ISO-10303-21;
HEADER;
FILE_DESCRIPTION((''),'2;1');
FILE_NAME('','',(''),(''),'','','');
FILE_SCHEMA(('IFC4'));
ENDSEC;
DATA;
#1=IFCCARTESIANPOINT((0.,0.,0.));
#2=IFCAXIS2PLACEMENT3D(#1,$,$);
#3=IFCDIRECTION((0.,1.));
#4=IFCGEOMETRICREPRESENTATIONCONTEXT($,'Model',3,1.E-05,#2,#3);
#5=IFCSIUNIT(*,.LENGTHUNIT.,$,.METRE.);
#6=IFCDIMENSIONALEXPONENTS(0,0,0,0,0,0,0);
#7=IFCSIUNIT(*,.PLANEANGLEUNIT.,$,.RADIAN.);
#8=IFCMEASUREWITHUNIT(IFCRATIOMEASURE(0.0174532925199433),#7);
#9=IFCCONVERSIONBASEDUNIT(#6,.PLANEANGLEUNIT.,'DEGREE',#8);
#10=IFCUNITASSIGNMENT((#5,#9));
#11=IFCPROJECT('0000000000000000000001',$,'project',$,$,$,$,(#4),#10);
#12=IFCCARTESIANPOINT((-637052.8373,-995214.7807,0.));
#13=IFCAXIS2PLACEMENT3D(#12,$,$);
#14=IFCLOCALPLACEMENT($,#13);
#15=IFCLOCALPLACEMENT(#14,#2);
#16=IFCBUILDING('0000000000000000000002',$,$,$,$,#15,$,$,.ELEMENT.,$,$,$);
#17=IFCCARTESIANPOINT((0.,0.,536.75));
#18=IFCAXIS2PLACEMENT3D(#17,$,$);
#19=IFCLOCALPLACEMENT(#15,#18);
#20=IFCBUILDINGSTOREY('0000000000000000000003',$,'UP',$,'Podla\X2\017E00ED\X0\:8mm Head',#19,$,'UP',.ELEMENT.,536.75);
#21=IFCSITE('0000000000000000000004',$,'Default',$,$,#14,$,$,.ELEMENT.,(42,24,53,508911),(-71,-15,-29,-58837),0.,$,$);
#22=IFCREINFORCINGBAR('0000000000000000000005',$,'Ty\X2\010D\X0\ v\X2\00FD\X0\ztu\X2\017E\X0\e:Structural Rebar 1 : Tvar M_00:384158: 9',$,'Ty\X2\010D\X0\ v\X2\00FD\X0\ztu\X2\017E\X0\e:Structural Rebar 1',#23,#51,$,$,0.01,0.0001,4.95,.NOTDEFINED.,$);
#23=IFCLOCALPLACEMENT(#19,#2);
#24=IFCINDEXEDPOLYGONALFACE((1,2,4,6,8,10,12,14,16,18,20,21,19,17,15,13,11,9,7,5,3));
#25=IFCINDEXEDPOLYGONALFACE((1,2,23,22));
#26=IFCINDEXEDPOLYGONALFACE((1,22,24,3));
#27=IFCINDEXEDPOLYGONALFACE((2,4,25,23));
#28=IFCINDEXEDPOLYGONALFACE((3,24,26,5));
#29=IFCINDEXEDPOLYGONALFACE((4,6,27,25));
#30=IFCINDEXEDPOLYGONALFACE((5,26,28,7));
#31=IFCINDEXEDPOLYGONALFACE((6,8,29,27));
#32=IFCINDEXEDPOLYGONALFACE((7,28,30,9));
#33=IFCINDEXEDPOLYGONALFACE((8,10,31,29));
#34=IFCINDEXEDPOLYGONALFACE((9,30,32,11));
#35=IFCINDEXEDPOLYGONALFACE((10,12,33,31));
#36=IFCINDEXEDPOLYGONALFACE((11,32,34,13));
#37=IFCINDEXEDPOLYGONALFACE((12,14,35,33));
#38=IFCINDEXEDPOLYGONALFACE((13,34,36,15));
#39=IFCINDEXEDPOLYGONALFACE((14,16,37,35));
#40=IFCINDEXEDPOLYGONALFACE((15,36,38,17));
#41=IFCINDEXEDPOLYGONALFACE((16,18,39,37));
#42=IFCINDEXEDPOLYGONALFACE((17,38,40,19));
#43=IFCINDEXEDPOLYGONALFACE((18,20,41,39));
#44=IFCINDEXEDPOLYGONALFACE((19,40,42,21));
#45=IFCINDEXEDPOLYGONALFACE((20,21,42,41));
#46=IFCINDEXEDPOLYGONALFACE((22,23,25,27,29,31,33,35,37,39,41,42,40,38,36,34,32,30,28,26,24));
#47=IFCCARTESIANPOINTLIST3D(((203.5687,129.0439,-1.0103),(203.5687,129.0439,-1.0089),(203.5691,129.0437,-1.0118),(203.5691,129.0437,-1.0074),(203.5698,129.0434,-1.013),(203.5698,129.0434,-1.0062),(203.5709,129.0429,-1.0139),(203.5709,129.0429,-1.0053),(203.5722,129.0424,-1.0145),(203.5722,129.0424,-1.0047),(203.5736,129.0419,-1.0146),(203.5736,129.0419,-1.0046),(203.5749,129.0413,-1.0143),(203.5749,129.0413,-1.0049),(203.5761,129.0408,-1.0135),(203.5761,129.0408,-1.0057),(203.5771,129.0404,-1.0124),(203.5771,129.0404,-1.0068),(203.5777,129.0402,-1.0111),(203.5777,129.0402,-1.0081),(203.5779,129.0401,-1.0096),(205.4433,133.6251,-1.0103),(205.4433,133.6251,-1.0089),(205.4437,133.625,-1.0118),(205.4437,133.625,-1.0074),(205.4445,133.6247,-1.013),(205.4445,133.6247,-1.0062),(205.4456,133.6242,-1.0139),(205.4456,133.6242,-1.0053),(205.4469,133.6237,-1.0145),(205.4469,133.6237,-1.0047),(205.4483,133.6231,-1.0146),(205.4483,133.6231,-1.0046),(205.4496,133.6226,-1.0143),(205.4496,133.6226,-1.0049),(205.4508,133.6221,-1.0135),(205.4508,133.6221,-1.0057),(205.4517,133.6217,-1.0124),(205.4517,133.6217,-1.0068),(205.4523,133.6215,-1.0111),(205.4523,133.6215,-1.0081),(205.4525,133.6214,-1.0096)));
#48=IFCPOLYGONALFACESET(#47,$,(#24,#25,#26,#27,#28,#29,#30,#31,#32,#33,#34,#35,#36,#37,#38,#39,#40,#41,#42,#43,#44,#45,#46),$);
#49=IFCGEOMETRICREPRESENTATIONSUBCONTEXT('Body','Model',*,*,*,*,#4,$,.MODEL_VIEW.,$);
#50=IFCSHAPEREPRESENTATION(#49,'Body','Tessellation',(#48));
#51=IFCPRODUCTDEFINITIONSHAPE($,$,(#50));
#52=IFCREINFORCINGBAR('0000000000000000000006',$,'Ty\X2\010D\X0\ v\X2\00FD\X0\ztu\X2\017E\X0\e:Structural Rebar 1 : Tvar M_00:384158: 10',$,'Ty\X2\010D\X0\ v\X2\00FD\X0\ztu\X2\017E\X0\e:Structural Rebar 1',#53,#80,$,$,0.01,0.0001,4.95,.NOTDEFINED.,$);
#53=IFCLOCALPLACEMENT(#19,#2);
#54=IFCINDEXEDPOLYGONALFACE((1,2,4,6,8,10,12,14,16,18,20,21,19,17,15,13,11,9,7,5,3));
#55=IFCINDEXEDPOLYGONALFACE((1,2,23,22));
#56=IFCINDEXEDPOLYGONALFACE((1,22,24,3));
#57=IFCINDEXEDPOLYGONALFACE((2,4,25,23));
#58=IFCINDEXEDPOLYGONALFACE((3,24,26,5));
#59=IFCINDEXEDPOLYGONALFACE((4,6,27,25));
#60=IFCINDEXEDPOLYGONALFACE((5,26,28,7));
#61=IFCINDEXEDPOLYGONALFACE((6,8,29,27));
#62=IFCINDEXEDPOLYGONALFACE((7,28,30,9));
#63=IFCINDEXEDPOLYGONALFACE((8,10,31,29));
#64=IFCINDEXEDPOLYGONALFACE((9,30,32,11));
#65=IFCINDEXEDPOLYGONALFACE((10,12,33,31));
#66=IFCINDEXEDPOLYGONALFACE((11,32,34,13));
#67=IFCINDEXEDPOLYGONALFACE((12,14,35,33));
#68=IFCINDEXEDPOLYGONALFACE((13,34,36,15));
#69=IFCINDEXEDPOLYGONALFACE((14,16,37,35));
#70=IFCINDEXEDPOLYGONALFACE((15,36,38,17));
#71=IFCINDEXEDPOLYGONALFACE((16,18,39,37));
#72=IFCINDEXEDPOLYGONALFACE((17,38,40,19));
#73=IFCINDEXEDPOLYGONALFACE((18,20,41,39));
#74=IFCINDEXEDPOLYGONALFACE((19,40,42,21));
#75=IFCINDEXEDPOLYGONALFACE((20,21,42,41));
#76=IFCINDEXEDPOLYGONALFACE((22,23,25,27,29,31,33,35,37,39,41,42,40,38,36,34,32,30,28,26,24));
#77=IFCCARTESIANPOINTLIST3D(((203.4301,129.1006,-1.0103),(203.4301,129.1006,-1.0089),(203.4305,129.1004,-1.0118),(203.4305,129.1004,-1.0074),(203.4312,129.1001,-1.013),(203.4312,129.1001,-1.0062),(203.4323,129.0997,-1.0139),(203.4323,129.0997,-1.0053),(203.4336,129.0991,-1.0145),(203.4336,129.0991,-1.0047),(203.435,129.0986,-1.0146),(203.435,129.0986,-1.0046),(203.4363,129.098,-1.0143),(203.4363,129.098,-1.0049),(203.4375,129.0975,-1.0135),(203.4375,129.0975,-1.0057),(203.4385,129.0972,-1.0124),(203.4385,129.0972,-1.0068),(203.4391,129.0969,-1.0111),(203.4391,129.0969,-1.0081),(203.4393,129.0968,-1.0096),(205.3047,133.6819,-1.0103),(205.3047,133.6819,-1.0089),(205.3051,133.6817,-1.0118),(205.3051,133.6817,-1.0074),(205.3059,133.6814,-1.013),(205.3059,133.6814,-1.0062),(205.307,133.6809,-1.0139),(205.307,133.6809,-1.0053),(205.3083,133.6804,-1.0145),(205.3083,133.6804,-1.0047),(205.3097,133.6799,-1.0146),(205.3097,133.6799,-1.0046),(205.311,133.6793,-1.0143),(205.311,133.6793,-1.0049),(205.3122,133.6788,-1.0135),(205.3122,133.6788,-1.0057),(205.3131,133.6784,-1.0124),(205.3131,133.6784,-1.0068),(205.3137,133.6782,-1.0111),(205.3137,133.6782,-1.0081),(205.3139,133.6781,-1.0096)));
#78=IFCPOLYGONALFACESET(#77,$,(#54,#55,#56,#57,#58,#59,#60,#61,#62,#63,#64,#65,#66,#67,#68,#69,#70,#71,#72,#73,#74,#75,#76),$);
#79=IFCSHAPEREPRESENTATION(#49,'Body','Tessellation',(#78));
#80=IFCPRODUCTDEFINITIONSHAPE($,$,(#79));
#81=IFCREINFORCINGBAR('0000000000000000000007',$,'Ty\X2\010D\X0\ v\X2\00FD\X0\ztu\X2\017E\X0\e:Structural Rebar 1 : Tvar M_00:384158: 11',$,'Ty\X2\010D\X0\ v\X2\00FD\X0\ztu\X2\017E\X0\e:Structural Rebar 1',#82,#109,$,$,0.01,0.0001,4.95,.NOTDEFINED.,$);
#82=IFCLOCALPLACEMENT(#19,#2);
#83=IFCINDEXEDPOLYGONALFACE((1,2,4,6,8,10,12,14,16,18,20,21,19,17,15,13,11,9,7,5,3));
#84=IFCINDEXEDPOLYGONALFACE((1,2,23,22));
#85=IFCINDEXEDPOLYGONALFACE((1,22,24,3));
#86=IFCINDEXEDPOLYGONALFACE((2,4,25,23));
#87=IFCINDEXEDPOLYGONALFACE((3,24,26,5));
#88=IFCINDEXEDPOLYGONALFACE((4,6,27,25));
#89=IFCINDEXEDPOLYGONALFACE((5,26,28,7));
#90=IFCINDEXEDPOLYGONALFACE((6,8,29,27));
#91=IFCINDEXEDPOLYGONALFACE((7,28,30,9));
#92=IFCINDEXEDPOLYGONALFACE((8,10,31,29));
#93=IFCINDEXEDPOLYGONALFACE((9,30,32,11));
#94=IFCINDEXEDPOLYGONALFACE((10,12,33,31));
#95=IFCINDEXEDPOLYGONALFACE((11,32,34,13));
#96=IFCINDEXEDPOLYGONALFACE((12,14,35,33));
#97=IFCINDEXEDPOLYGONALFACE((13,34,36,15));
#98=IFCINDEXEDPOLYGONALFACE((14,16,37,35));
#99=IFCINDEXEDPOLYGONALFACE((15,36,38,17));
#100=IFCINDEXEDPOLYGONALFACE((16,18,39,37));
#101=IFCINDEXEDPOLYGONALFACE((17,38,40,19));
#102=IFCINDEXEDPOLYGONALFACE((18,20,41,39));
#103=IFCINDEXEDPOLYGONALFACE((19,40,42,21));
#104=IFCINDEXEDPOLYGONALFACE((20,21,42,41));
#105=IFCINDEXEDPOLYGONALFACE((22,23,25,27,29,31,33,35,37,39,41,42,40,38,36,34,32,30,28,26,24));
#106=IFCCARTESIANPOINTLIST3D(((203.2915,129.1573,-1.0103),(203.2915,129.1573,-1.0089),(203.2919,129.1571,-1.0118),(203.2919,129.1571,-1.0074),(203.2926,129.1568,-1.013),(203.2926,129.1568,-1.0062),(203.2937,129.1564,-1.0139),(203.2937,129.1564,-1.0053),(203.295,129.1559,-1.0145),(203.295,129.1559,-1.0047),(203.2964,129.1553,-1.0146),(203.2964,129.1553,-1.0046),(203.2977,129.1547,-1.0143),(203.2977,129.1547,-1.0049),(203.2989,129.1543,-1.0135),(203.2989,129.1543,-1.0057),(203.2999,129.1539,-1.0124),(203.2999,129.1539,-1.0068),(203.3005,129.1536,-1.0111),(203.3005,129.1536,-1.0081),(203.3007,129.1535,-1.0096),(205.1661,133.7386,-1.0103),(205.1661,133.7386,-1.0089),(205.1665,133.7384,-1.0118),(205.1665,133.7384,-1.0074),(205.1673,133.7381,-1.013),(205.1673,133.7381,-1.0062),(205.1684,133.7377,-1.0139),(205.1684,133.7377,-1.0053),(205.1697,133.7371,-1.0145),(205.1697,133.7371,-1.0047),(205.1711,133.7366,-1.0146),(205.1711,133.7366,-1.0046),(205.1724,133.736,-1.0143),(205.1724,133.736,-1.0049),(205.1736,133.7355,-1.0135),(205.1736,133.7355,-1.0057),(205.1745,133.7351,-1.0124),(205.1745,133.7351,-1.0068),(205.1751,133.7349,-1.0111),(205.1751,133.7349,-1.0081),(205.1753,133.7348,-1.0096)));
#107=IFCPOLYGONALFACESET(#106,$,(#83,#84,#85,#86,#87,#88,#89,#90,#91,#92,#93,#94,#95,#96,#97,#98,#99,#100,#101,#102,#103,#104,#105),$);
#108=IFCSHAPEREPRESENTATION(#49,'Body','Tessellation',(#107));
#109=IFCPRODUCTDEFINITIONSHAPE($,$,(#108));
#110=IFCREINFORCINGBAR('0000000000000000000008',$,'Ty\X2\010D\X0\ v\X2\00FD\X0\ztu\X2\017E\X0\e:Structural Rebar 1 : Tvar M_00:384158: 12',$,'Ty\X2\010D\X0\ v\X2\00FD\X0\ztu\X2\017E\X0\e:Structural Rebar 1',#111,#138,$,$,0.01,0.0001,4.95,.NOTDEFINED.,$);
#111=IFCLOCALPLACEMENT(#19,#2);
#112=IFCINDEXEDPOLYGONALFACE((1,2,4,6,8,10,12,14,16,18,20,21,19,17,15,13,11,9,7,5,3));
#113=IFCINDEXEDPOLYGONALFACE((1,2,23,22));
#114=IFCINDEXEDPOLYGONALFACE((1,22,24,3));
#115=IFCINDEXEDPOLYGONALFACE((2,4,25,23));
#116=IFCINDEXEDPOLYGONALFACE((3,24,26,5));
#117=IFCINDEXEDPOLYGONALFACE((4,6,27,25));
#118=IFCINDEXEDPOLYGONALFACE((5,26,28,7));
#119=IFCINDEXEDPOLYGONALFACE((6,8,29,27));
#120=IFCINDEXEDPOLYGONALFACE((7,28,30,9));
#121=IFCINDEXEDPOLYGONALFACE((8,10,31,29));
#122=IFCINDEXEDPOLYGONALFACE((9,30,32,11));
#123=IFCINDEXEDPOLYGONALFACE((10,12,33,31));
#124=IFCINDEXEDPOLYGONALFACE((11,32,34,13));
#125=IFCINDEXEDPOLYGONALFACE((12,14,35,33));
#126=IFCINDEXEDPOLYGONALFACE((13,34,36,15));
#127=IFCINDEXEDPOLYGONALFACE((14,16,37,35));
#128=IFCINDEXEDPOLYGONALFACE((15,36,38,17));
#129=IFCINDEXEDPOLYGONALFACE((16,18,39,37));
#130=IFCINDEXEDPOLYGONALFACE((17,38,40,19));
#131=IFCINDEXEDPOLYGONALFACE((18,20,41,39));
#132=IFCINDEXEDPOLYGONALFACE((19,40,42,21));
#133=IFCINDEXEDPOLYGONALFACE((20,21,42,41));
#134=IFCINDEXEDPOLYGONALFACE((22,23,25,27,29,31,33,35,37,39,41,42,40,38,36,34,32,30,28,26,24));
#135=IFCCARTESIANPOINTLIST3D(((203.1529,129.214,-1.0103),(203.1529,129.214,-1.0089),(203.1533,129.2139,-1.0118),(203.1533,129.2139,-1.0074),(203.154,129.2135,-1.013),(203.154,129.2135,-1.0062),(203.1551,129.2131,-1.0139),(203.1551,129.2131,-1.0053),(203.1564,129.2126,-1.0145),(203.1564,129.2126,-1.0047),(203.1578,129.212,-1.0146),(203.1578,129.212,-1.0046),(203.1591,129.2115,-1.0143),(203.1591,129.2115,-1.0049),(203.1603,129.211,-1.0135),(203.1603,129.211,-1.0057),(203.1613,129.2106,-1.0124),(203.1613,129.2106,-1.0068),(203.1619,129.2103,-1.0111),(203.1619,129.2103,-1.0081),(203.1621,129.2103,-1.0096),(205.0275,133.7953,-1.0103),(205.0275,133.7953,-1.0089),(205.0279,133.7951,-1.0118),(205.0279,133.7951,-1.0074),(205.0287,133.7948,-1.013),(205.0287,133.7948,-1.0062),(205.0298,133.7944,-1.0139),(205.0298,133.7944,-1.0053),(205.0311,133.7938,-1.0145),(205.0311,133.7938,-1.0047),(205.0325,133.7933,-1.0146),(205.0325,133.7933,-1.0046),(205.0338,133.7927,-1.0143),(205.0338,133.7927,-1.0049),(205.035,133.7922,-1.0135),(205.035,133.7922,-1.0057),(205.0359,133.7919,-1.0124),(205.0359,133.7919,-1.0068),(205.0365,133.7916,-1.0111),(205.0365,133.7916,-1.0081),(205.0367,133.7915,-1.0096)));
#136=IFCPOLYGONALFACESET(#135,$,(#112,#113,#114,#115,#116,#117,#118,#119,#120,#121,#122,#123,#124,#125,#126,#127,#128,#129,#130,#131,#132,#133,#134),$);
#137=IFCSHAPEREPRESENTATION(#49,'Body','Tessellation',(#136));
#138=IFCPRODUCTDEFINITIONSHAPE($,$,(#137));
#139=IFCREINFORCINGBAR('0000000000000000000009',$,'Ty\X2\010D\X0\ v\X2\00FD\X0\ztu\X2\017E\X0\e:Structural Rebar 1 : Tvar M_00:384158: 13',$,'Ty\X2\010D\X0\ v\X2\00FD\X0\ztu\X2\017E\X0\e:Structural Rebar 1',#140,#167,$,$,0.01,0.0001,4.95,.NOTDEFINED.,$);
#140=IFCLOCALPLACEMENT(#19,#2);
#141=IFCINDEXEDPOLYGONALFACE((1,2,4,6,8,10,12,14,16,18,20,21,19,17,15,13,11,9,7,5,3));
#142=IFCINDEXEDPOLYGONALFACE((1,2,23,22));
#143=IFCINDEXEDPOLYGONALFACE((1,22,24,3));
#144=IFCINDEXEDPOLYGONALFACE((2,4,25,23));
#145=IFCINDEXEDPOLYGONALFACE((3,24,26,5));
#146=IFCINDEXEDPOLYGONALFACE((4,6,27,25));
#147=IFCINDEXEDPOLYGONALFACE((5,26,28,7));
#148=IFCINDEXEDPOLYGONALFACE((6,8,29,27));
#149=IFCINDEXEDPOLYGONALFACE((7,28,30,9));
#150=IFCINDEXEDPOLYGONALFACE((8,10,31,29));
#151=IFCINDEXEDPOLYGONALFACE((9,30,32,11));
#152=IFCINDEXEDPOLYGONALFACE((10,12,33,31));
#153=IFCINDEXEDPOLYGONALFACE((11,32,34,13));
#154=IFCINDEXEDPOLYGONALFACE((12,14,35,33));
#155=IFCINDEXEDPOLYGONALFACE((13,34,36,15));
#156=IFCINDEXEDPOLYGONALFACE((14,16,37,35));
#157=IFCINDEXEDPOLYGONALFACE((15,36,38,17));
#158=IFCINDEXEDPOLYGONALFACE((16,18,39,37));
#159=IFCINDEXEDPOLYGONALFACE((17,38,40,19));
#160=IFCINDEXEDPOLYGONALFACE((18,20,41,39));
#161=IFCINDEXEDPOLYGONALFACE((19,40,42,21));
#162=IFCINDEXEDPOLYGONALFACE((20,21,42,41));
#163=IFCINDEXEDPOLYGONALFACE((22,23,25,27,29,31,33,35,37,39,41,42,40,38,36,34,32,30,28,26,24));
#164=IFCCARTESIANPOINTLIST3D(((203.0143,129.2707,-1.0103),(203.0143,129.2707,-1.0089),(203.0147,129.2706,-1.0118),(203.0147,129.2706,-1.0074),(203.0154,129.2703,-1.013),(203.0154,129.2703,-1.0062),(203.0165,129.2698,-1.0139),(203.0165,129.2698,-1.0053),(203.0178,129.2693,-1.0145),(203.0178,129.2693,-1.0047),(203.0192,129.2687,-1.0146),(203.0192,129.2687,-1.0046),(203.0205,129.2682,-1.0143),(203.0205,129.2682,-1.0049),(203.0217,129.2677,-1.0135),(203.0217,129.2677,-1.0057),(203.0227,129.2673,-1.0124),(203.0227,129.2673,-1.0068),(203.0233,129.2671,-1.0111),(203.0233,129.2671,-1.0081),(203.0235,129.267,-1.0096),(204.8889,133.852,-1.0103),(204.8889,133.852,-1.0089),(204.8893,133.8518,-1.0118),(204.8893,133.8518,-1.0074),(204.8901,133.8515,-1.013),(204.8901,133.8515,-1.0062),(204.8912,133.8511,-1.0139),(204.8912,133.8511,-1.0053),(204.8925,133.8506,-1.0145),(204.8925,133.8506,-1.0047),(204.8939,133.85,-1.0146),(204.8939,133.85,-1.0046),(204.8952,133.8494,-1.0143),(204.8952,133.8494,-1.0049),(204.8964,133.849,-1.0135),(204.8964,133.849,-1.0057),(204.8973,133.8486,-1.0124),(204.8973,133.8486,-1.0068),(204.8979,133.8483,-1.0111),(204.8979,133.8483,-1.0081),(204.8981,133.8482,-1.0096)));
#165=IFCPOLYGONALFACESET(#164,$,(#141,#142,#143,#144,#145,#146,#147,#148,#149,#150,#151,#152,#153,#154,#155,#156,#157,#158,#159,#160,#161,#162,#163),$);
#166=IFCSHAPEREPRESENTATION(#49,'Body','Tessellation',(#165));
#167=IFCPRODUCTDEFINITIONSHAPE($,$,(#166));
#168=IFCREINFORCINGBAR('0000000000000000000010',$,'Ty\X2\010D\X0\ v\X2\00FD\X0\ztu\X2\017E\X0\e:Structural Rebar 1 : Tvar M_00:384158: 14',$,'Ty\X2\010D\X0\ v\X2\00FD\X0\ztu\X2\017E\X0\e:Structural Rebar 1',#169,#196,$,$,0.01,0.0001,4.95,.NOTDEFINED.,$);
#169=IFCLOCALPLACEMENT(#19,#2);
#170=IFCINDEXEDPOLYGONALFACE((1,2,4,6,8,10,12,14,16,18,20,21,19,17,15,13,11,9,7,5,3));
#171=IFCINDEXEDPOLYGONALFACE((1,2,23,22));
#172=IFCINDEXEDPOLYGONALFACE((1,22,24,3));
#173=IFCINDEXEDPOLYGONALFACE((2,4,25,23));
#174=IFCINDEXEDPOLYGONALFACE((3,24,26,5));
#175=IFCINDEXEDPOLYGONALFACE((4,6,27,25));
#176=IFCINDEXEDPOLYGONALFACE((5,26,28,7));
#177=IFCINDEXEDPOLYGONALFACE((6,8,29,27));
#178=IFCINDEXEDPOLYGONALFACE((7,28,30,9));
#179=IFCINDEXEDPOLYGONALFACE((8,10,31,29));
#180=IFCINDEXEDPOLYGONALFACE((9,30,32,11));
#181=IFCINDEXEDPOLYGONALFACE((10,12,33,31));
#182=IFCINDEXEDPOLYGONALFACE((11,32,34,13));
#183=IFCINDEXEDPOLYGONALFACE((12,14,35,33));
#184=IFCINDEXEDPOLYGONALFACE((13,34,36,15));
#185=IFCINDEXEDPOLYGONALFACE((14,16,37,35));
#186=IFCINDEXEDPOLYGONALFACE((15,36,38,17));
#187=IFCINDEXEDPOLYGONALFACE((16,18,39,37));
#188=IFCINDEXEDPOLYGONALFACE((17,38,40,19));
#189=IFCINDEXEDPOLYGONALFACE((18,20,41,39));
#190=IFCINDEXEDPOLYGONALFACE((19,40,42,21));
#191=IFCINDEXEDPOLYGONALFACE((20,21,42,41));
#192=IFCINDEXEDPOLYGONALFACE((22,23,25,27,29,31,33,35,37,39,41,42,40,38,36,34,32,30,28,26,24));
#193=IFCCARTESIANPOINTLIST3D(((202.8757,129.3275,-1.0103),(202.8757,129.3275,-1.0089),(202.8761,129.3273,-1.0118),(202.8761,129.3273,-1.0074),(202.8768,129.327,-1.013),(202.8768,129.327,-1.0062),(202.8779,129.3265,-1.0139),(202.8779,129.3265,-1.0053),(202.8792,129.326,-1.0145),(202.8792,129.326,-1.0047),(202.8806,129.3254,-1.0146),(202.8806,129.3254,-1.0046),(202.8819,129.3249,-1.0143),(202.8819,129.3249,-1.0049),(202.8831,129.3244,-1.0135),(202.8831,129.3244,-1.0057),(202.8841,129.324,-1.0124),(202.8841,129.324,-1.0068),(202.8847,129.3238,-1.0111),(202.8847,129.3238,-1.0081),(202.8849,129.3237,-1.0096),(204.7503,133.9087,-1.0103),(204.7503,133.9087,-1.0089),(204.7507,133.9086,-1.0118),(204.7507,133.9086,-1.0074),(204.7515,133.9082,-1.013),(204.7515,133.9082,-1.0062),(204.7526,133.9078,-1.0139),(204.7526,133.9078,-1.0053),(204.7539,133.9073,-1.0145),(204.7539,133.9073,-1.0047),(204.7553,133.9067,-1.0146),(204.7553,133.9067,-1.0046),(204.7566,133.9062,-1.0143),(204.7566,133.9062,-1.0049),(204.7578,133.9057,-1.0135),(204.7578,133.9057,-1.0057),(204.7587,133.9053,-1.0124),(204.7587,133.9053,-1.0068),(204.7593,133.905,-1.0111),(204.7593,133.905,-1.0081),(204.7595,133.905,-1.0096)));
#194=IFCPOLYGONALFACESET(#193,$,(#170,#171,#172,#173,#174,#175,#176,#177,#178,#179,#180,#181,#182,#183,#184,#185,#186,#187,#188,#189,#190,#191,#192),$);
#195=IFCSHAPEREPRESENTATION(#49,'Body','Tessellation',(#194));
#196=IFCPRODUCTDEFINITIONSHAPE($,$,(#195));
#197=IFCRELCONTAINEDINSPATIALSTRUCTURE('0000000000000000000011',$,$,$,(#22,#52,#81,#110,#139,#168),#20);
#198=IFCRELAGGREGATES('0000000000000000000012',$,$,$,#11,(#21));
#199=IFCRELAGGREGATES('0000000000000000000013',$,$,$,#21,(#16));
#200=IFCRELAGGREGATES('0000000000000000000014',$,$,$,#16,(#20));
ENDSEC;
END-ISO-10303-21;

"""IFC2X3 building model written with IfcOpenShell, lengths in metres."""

from ifc_helpers import new_model, entity, si_unit, converted_unit, direction, frame, origin, place, context, subcontext, project, spatial, element, save


model = new_model("IFC2X3")

# Units and contexts
model_context = context("Model", 3, precision=1e-05, world=origin(), true_north=direction((0.0, 1.0)))
body_context = subcontext(model_context, "Body", "Model", "MODEL_VIEW")
ifc_project = project(units=[si_unit("LENGTHUNIT", "METRE"), converted_unit("PLANEANGLEUNIT", "DEGREE", entity("IfcRatioMeasure", 0.0174532925199433), si_unit("PLANEANGLEUNIT", "RADIAN"), dimensions=[0, 0, 0, 0, 0, 0, 0])], contexts=[model_context])

# Site, building, storey
site_placement = place(None, frame((-637052.8373, -995214.7807, 0.0)))
site = spatial("IfcSite", under=ifc_project, at=site_placement, Name="Default", CompositionType="ELEMENT", RefLatitude=(42, 24, 53, 508911), RefLongitude=(-71, -15, -29, -58837), RefElevation=0.0)
building_placement = place(site_placement, origin())
building = spatial("IfcBuilding", under=site, at=building_placement, CompositionType="ELEMENT")
storey_placement = place(building_placement, frame((0.0, 0.0, 536.75)))
storey = spatial("IfcBuildingStorey", under=building, at=storey_placement, Name="UP", ObjectType="Podlaží:8mm Head", LongName="UP", CompositionType="ELEMENT", Elevation=536.75)

# Reinforcing bars
reinforcing_bar_1_placement = place(storey_placement, origin())
element("IfcReinforcingBar", 1, at=reinforcing_bar_1_placement, inside=storey, Name="Tyč výztuže:Structural Rebar 1 : Tvar M_00:384158: 9", ObjectType="Tyč výztuže:Structural Rebar 1", BarLength=4.95, BarRole="NOTDEFINED", CrossSectionArea=0.0001, NominalDiameter=0.01, context=body_context, shape_type="AdvancedSweptSolid", body=[
    entity("IfcSweptDiskSolid", entity("IfcCompositeCurve", [entity("IfcCompositeCurveSegment", "CONTINUOUS", True, entity("IfcPolyline", [entity("IfcCartesianPoint", [-205.4479, -133.6233, 1.0096]), entity("IfcCartesianPoint", [-203.5732, -129.042, 1.0096])]))], False), 0.005, None, 0.0, 1.0),
])
reinforcing_bar_2_placement = place(storey_placement, origin())
element("IfcReinforcingBar", 2, at=reinforcing_bar_2_placement, inside=storey, Name="Tyč výztuže:Structural Rebar 1 : Tvar M_00:384158: 10", ObjectType="Tyč výztuže:Structural Rebar 1", BarLength=4.95, BarRole="NOTDEFINED", CrossSectionArea=0.0001, NominalDiameter=0.01, context=body_context, shape_type="AdvancedSweptSolid", body=[
    entity("IfcSweptDiskSolid", entity("IfcCompositeCurve", [entity("IfcCompositeCurveSegment", "CONTINUOUS", True, entity("IfcPolyline", [entity("IfcCartesianPoint", [-205.3093, -133.68, 1.0096]), entity("IfcCartesianPoint", [-203.4346, -129.0987, 1.0096])]))], False), 0.005, None, 0.0, 1.0),
])
reinforcing_bar_3_placement = place(storey_placement, origin())
element("IfcReinforcingBar", 3, at=reinforcing_bar_3_placement, inside=storey, Name="Tyč výztuže:Structural Rebar 1 : Tvar M_00:384158: 11", ObjectType="Tyč výztuže:Structural Rebar 1", BarLength=4.95, BarRole="NOTDEFINED", CrossSectionArea=0.0001, NominalDiameter=0.01, context=body_context, shape_type="AdvancedSweptSolid", body=[
    entity("IfcSweptDiskSolid", entity("IfcCompositeCurve", [entity("IfcCompositeCurveSegment", "CONTINUOUS", True, entity("IfcPolyline", [entity("IfcCartesianPoint", [-205.1707, -133.7367, 1.0096]), entity("IfcCartesianPoint", [-203.296, -129.1554, 1.0096])]))], False), 0.005, None, 0.0, 1.0),
])
reinforcing_bar_4_placement = place(storey_placement, origin())
element("IfcReinforcingBar", 4, at=reinforcing_bar_4_placement, inside=storey, Name="Tyč výztuže:Structural Rebar 1 : Tvar M_00:384158: 12", ObjectType="Tyč výztuže:Structural Rebar 1", BarLength=4.95, BarRole="NOTDEFINED", CrossSectionArea=0.0001, NominalDiameter=0.01, context=body_context, shape_type="AdvancedSweptSolid", body=[
    entity("IfcSweptDiskSolid", entity("IfcCompositeCurve", [entity("IfcCompositeCurveSegment", "CONTINUOUS", True, entity("IfcPolyline", [entity("IfcCartesianPoint", [-205.0321, -133.7934, 1.0096]), entity("IfcCartesianPoint", [-203.1574, -129.2121, 1.0096])]))], False), 0.005, None, 0.0, 1.0),
])
reinforcing_bar_5_placement = place(storey_placement, origin())
element("IfcReinforcingBar", 5, at=reinforcing_bar_5_placement, inside=storey, Name="Tyč výztuže:Structural Rebar 1 : Tvar M_00:384158: 13", ObjectType="Tyč výztuže:Structural Rebar 1", BarLength=4.95, BarRole="NOTDEFINED", CrossSectionArea=0.0001, NominalDiameter=0.01, context=body_context, shape_type="AdvancedSweptSolid", body=[
    entity("IfcSweptDiskSolid", entity("IfcCompositeCurve", [entity("IfcCompositeCurveSegment", "CONTINUOUS", True, entity("IfcPolyline", [entity("IfcCartesianPoint", [-204.8935, -133.8501, 1.0096]), entity("IfcCartesianPoint", [-203.0188, -129.2689, 1.0096])]))], False), 0.005, None, 0.0, 1.0),
])
reinforcing_bar_6_placement = place(storey_placement, origin())
element("IfcReinforcingBar", 6, at=reinforcing_bar_6_placement, inside=storey, Name="Tyč výztuže:Structural Rebar 1 : Tvar M_00:384158: 14", ObjectType="Tyč výztuže:Structural Rebar 1", BarLength=4.95, BarRole="NOTDEFINED", CrossSectionArea=0.0001, NominalDiameter=0.01, context=body_context, shape_type="AdvancedSweptSolid", body=[
    entity("IfcSweptDiskSolid", entity("IfcCompositeCurve", [entity("IfcCompositeCurveSegment", "CONTINUOUS", True, entity("IfcPolyline", [entity("IfcCartesianPoint", [-204.7549, -133.9069, 1.0096]), entity("IfcCartesianPoint", [-202.8802, -129.3256, 1.0096])]))], False), 0.005, None, 0.0, 1.0),
])

save(model, "model.ifc")
